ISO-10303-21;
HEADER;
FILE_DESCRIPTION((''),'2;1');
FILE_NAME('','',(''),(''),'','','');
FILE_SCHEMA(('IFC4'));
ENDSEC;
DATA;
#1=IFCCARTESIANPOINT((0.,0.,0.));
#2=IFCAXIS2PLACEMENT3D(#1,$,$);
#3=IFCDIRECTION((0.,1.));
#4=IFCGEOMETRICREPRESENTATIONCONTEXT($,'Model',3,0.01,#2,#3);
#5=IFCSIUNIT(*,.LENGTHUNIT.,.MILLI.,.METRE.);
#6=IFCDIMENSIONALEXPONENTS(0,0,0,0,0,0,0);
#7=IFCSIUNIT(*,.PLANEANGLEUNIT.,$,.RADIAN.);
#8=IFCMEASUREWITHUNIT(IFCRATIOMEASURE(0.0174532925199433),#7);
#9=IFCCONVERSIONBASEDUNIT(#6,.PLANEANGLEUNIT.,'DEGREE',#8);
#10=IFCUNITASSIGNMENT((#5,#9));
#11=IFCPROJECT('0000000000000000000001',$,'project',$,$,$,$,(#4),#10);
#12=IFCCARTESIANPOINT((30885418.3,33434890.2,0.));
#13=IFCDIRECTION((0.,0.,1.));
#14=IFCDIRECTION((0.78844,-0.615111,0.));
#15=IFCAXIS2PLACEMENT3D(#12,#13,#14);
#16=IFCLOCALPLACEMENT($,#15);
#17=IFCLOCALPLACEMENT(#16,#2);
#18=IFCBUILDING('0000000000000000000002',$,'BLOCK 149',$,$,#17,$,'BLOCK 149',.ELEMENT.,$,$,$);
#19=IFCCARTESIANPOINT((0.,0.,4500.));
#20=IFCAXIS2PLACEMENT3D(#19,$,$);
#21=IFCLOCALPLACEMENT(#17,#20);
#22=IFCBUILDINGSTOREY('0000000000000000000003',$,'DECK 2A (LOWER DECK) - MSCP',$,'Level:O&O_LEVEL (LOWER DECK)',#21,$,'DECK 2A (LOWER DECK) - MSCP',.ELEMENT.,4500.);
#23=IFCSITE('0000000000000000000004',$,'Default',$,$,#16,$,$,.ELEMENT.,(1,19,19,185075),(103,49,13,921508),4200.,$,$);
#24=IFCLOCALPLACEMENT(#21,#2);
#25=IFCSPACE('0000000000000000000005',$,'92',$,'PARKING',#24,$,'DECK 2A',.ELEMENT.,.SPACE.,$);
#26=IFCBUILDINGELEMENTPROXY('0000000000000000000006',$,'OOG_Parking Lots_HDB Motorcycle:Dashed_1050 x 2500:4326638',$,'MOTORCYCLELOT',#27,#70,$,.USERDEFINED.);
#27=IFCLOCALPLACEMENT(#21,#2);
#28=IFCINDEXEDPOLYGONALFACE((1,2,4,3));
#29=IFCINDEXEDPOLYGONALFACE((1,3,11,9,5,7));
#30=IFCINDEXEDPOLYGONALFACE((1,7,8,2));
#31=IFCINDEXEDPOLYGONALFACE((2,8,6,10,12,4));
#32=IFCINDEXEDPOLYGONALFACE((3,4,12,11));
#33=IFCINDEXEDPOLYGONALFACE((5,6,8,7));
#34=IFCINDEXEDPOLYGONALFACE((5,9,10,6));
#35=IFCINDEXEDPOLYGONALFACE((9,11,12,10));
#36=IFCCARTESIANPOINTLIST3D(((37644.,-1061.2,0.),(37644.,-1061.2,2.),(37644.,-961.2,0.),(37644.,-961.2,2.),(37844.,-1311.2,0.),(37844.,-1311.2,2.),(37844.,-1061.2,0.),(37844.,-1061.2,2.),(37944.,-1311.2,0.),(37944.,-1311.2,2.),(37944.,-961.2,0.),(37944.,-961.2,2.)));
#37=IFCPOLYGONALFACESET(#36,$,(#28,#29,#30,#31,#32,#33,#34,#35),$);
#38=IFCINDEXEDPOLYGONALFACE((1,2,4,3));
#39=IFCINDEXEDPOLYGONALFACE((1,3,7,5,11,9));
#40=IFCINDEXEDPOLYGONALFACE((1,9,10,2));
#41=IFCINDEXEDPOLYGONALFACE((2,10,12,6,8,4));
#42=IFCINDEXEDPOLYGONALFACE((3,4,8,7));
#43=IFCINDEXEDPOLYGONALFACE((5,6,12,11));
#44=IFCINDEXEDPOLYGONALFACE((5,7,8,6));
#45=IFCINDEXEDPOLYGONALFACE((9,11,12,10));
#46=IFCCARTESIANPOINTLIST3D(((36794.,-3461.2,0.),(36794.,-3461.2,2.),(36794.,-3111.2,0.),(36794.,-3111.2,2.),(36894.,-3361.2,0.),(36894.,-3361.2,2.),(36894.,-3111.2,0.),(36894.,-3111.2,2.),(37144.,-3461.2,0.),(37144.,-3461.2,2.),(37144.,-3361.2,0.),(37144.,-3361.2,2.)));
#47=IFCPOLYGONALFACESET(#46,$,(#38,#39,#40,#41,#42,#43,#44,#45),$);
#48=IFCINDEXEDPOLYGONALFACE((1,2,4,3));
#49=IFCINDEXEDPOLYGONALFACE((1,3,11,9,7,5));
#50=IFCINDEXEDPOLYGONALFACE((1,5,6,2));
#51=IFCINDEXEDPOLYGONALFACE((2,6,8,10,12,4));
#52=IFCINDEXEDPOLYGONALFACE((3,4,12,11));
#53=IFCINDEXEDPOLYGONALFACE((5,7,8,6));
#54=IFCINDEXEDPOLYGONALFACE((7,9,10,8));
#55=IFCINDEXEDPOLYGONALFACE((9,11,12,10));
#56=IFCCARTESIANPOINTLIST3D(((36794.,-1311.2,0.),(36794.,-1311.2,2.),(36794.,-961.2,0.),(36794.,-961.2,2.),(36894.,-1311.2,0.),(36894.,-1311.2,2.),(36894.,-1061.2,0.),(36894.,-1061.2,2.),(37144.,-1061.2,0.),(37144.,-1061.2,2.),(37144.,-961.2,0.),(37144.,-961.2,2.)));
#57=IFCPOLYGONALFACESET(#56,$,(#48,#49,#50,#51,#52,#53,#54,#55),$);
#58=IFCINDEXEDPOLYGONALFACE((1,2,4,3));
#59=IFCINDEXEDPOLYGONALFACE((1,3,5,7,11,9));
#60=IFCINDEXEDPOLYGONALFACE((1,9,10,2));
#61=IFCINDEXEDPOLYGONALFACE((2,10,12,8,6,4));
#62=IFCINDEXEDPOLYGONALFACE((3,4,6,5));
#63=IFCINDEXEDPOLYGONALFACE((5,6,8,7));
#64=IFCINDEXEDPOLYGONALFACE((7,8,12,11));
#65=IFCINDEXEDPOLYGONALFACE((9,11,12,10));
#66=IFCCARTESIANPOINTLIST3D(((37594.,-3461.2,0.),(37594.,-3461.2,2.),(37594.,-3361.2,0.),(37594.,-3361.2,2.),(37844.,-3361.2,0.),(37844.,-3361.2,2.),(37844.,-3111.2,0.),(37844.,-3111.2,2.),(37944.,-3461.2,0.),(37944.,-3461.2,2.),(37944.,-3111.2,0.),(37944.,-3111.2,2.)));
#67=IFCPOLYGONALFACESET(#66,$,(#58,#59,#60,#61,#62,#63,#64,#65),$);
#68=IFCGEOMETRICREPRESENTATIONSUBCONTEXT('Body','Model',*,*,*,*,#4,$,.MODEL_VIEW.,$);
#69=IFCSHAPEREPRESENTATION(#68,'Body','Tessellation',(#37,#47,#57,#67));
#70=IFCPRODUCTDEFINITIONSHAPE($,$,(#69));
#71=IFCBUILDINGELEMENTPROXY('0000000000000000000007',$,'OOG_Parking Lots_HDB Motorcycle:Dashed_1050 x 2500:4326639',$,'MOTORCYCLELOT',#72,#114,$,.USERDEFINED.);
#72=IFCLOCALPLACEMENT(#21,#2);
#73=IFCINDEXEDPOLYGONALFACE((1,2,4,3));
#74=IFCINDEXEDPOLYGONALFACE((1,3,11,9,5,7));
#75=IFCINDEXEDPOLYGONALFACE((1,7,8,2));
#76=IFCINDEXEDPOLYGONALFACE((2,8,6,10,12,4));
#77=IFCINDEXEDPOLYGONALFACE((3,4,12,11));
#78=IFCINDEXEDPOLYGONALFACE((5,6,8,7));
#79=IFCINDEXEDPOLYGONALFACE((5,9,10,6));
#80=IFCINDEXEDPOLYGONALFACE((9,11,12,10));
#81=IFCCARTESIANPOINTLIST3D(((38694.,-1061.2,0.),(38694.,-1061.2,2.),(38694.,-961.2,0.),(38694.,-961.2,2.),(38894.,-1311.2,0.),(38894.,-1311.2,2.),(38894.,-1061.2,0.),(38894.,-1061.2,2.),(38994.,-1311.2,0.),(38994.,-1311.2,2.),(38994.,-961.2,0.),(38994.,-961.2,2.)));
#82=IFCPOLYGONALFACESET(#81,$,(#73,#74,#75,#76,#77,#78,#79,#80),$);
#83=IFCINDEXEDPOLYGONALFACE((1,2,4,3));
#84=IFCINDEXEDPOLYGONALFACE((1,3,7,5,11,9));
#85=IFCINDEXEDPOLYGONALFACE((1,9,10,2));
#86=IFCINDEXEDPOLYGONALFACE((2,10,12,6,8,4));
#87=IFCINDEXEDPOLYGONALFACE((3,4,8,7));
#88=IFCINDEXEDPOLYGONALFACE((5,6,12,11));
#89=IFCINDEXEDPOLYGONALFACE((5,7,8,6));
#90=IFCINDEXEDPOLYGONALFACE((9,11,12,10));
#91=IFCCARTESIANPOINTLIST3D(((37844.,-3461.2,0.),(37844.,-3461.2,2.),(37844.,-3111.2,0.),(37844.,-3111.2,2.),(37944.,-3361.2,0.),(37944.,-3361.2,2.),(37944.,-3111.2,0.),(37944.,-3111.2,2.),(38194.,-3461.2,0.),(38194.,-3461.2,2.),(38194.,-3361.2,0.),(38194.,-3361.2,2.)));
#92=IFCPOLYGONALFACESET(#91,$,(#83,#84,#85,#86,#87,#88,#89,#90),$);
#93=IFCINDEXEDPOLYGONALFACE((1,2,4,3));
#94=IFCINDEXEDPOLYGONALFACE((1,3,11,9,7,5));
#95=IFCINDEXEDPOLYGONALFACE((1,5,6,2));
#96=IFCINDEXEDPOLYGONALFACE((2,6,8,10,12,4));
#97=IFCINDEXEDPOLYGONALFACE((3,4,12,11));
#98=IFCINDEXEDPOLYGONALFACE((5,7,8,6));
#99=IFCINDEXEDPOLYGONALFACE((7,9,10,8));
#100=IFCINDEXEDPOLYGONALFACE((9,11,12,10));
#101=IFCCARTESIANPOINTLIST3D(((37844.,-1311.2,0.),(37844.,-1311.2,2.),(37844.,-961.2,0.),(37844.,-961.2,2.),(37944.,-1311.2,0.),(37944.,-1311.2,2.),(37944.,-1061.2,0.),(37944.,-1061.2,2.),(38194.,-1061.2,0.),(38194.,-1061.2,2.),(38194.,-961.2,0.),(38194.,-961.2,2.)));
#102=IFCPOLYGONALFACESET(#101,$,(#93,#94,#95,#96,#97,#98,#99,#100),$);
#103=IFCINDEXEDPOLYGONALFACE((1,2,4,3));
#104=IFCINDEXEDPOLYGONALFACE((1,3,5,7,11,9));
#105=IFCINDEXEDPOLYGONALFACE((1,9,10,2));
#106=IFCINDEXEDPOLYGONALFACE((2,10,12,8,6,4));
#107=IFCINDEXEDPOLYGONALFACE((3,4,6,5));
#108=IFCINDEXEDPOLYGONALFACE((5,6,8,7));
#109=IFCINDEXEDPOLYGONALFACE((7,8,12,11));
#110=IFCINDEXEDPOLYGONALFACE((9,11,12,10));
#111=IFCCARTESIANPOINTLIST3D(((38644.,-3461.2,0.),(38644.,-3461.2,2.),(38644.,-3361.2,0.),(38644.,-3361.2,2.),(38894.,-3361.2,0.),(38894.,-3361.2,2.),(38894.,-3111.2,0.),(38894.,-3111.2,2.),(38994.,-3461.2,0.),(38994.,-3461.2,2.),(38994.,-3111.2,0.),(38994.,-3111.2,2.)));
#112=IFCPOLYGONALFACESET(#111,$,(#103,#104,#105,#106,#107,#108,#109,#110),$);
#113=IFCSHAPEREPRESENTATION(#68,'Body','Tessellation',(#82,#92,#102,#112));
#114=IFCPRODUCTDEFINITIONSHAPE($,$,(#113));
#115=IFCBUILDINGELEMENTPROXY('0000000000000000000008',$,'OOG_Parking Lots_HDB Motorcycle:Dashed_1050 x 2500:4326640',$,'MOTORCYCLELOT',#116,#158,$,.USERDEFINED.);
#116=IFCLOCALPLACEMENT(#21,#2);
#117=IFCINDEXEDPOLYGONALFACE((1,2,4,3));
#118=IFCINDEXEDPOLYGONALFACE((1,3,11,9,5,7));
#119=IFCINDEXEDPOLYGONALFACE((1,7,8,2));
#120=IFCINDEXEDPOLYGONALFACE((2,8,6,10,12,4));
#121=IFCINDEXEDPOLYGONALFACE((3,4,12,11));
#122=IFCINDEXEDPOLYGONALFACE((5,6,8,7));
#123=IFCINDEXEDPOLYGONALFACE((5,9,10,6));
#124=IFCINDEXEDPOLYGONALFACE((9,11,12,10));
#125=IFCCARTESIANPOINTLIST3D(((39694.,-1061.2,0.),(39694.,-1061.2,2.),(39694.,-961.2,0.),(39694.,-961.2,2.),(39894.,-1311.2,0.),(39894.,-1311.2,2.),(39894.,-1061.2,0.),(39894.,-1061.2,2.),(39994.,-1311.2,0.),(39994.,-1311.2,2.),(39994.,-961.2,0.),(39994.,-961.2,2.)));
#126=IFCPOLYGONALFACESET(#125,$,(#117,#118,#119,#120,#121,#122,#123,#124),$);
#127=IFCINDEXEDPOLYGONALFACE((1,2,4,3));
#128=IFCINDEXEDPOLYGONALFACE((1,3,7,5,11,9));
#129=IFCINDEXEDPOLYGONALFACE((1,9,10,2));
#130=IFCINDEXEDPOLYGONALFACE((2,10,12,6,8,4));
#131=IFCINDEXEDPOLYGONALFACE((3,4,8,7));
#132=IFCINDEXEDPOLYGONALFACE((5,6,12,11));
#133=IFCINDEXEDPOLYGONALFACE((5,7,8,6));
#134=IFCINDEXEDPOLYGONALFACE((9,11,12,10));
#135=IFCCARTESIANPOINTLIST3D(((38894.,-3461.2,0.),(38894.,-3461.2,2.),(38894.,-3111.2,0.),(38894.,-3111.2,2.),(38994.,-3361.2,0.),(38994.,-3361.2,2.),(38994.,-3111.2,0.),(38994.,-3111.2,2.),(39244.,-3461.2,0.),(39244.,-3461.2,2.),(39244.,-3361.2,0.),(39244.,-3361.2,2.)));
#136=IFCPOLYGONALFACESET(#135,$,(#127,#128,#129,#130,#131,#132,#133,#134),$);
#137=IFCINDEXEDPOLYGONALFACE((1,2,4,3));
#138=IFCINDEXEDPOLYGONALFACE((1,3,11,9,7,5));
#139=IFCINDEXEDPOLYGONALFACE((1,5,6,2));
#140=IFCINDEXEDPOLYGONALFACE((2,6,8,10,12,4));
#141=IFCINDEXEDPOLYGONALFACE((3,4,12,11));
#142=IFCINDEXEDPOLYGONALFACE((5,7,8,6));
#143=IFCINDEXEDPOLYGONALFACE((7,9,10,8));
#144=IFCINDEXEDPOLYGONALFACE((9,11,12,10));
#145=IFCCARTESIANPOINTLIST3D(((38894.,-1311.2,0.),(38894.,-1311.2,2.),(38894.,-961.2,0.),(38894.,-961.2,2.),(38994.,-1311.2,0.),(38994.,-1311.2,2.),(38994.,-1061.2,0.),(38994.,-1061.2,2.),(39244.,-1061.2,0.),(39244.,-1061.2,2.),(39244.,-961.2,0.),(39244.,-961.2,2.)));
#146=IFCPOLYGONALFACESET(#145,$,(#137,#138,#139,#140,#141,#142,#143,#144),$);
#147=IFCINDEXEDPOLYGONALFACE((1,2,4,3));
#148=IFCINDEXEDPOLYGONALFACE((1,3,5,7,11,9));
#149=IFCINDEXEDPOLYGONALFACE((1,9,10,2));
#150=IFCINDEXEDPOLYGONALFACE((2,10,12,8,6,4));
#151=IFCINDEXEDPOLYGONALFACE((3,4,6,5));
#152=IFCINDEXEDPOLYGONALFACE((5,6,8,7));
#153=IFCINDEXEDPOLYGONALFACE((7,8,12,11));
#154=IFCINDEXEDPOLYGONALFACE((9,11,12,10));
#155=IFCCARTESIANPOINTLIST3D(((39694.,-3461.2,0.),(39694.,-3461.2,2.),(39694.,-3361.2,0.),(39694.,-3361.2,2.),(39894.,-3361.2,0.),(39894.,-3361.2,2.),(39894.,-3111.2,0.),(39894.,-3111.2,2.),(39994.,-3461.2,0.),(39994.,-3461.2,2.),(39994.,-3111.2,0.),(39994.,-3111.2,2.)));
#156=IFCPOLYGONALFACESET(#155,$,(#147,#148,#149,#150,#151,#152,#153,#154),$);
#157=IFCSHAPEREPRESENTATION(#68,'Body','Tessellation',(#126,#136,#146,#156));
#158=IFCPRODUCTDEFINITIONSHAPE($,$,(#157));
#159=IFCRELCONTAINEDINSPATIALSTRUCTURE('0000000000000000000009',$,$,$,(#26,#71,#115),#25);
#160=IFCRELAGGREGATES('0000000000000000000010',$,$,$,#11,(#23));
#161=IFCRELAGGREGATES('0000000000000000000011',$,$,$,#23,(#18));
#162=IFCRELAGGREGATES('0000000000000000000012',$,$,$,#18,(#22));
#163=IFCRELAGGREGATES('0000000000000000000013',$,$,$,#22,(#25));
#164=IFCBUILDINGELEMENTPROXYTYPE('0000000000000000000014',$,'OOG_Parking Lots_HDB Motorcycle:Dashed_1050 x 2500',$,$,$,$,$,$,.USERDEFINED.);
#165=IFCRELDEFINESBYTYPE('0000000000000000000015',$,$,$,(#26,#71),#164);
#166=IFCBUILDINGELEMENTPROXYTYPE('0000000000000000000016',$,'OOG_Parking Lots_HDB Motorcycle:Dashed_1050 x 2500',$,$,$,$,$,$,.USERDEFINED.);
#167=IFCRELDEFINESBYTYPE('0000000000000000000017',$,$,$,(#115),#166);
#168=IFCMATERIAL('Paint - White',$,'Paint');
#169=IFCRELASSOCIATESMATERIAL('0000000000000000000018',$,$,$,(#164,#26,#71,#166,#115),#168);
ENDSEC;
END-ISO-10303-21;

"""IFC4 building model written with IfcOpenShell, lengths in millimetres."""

from ifc_helpers import new_model, entity, si_unit, converted_unit, direction, frame, origin, place, context, subcontext, project, spatial, indexed_curve, outline, extrude, source, transform, mapped, material, type_object, type_shapes, element, save


model = new_model("IFC4")

# Units and contexts
model_context = context("Model", 3, precision=0.01, world=origin(), true_north=direction((0.0, 1.0)))
body_context = subcontext(model_context, "Body", "Model", "MODEL_VIEW")
ifc_project = project(units=[si_unit("LENGTHUNIT", "METRE", prefix="MILLI"), converted_unit("PLANEANGLEUNIT", "DEGREE", entity("IfcRatioMeasure", 0.0174532925199433), si_unit("PLANEANGLEUNIT", "RADIAN"), dimensions=[0, 0, 0, 0, 0, 0, 0])], contexts=[model_context])

# Site, building, storey
site_placement = place(None, frame((30885418.3, 33434890.2, 0.0), z_axis=(0.0, 0.0, 1.0), x_axis=(0.78844, -0.615111, 0.0)))
site = spatial("IfcSite", under=ifc_project, at=site_placement, Name="Default", CompositionType="ELEMENT", RefLatitude=(1, 19, 19, 185075), RefLongitude=(103, 49, 13, 921508), RefElevation=4200.0)
building_placement = place(site_placement, origin())
building = spatial("IfcBuilding", under=site, at=building_placement, Name="BLOCK 149", LongName="BLOCK 149", CompositionType="ELEMENT")
storey_placement = place(building_placement, frame((0.0, 0.0, 4500.0)))
storey = spatial("IfcBuildingStorey", under=building, at=storey_placement, Name="DECK 2A (LOWER DECK) - MSCP", ObjectType="Level:O&O_LEVEL (LOWER DECK)", LongName="DECK 2A (LOWER DECK) - MSCP", CompositionType="ELEMENT", Elevation=4500.0)

# Shared definitions
space_placement = place(storey_placement, origin())
space = spatial("IfcSpace", under=storey, at=space_placement, Name="92", ObjectType="PARKING", LongName="DECK 2A", CompositionType="ELEMENT", PredefinedType="SPACE")

# Building element proxies
ifc_material_1 = material(Name="Paint - White", Category="Paint")
building_element_proxy_type_1 = type_object("IfcBuildingElementProxyType", Name="OOG_Parking Lots_HDB Motorcycle:Dashed_1050 x 2500", PredefinedType="USERDEFINED", material=ifc_material_1)
shared_shape_1 = source(origin(), body_context, "Body", "SweptSolid", [
    extrude(outline(indexed_curve([(-200.0, -133.3), (150.0, -133.3), (150.0, 166.7), (50.0, 166.7), (50.0, -33.3), (-200.0, -33.3), (-200.0, -133.3)], self_intersect=False)), frame((966.7, -100.0, 0.0), z_axis=(0.0, 0.0, 1.0), x_axis=(0.0, 1.0, 0.0)), (0.0, 0.0, 1.0), 2.0),
    extrude(outline(indexed_curve([(-200.0, -150.0), (150.0, -150.0), (150.0, 200.0), (50.0, 200.0), (50.0, -50.0), (-200.0, -50.0), (-200.0, -150.0)], self_intersect=False)), frame((100.0, -2300.0, 0.0), z_axis=(0.0, 0.0, 1.0), x_axis=(0.0, -1.0, 0.0)), (0.0, 0.0, 1.0), 2.0),
    extrude(outline(indexed_curve([(-200.0, -150.0), (150.0, -150.0), (150.0, 200.0), (50.0, 200.0), (50.0, -50.0), (-200.0, -50.0), (-200.0, -150.0)], self_intersect=False)), frame((100.0, -100.0, 0.0), z_axis=(0.0, 0.0, 1.0), x_axis=(-1.0, 0.0, 0.0)), (0.0, 0.0, 1.0), 2.0),
    extrude(outline(indexed_curve([(-200.0, -150.0), (150.0, -150.0), (150.0, 200.0), (50.0, 200.0), (50.0, -50.0), (-200.0, -50.0), (-200.0, -150.0)], self_intersect=False)), frame((950.0, -2300.0, 0.0)), (0.0, 0.0, 1.0), 2.0),
])
type_shapes(building_element_proxy_type_1, [shared_shape_1])
for number, where, name in (
    (1, (36844.0, -1011.2, 0.0), "OOG_Parking Lots_HDB Motorcycle:Dashed_1050 x 2500:4326638"),
    (2, (37894.0, -1011.2, 0.0), "OOG_Parking Lots_HDB Motorcycle:Dashed_1050 x 2500:4326639"),
):
    element("IfcBuildingElementProxy", number, at=place(space_placement, frame(where)), inside=space, type_object=building_element_proxy_type_1, material=ifc_material_1, Name=name, ObjectType="MOTORCYCLELOT", PredefinedType="USERDEFINED", context=body_context, shape_type="MappedRepresentation", body=[
        mapped(shared_shape_1, transform((0.0, 0.0, 0.0), scale=1.0)),
    ])
building_element_proxy_type_2 = type_object("IfcBuildingElementProxyType", Name="OOG_Parking Lots_HDB Motorcycle:Dashed_1050 x 2500", PredefinedType="USERDEFINED", material=ifc_material_1)
shared_shape_2 = source(origin(), body_context, "Body", "SweptSolid", [
    extrude(outline(indexed_curve([(-200.0, -133.3), (150.0, -133.3), (150.0, 166.7), (50.0, 166.7), (50.0, -33.3), (-200.0, -33.3), (-200.0, -133.3)], self_intersect=False)), frame((916.7, -100.0, 0.0), z_axis=(0.0, 0.0, 1.0), x_axis=(0.0, 1.0, 0.0)), (0.0, 0.0, 1.0), 2.0),
    extrude(outline(indexed_curve([(-200.0, -150.0), (150.0, -150.0), (150.0, 200.0), (50.0, 200.0), (50.0, -50.0), (-200.0, -50.0), (-200.0, -150.0)], self_intersect=False)), frame((100.0, -2300.0, 0.0), z_axis=(0.0, 0.0, 1.0), x_axis=(0.0, -1.0, 0.0)), (0.0, 0.0, 1.0), 2.0),
    extrude(outline(indexed_curve([(-200.0, -150.0), (150.0, -150.0), (150.0, 200.0), (50.0, 200.0), (50.0, -50.0), (-200.0, -50.0), (-200.0, -150.0)], self_intersect=False)), frame((100.0, -100.0, 0.0), z_axis=(0.0, 0.0, 1.0), x_axis=(-1.0, 0.0, 0.0)), (0.0, 0.0, 1.0), 2.0),
    extrude(outline(indexed_curve([(-166.7, -150.0), (133.3, -150.0), (133.3, 200.0), (33.3, 200.0), (33.3, -50.0), (-166.7, -50.0), (-166.7, -150.0)], self_intersect=False)), frame((916.7, -2300.0, 0.0)), (0.0, 0.0, 1.0), 2.0),
])
type_shapes(building_element_proxy_type_2, [shared_shape_2])
proxy_1_placement = place(space_placement, frame((38944.0, -1011.2, 0.0)))
element("IfcBuildingElementProxy", 3, at=proxy_1_placement, inside=space, type_object=building_element_proxy_type_2, material=ifc_material_1, Name="OOG_Parking Lots_HDB Motorcycle:Dashed_1050 x 2500:4326640", ObjectType="MOTORCYCLELOT", PredefinedType="USERDEFINED", context=body_context, shape_type="MappedRepresentation", body=[
    mapped(shared_shape_2, transform((0.0, 0.0, 0.0), scale=1.0)),
])

save(model, "model.ifc")
